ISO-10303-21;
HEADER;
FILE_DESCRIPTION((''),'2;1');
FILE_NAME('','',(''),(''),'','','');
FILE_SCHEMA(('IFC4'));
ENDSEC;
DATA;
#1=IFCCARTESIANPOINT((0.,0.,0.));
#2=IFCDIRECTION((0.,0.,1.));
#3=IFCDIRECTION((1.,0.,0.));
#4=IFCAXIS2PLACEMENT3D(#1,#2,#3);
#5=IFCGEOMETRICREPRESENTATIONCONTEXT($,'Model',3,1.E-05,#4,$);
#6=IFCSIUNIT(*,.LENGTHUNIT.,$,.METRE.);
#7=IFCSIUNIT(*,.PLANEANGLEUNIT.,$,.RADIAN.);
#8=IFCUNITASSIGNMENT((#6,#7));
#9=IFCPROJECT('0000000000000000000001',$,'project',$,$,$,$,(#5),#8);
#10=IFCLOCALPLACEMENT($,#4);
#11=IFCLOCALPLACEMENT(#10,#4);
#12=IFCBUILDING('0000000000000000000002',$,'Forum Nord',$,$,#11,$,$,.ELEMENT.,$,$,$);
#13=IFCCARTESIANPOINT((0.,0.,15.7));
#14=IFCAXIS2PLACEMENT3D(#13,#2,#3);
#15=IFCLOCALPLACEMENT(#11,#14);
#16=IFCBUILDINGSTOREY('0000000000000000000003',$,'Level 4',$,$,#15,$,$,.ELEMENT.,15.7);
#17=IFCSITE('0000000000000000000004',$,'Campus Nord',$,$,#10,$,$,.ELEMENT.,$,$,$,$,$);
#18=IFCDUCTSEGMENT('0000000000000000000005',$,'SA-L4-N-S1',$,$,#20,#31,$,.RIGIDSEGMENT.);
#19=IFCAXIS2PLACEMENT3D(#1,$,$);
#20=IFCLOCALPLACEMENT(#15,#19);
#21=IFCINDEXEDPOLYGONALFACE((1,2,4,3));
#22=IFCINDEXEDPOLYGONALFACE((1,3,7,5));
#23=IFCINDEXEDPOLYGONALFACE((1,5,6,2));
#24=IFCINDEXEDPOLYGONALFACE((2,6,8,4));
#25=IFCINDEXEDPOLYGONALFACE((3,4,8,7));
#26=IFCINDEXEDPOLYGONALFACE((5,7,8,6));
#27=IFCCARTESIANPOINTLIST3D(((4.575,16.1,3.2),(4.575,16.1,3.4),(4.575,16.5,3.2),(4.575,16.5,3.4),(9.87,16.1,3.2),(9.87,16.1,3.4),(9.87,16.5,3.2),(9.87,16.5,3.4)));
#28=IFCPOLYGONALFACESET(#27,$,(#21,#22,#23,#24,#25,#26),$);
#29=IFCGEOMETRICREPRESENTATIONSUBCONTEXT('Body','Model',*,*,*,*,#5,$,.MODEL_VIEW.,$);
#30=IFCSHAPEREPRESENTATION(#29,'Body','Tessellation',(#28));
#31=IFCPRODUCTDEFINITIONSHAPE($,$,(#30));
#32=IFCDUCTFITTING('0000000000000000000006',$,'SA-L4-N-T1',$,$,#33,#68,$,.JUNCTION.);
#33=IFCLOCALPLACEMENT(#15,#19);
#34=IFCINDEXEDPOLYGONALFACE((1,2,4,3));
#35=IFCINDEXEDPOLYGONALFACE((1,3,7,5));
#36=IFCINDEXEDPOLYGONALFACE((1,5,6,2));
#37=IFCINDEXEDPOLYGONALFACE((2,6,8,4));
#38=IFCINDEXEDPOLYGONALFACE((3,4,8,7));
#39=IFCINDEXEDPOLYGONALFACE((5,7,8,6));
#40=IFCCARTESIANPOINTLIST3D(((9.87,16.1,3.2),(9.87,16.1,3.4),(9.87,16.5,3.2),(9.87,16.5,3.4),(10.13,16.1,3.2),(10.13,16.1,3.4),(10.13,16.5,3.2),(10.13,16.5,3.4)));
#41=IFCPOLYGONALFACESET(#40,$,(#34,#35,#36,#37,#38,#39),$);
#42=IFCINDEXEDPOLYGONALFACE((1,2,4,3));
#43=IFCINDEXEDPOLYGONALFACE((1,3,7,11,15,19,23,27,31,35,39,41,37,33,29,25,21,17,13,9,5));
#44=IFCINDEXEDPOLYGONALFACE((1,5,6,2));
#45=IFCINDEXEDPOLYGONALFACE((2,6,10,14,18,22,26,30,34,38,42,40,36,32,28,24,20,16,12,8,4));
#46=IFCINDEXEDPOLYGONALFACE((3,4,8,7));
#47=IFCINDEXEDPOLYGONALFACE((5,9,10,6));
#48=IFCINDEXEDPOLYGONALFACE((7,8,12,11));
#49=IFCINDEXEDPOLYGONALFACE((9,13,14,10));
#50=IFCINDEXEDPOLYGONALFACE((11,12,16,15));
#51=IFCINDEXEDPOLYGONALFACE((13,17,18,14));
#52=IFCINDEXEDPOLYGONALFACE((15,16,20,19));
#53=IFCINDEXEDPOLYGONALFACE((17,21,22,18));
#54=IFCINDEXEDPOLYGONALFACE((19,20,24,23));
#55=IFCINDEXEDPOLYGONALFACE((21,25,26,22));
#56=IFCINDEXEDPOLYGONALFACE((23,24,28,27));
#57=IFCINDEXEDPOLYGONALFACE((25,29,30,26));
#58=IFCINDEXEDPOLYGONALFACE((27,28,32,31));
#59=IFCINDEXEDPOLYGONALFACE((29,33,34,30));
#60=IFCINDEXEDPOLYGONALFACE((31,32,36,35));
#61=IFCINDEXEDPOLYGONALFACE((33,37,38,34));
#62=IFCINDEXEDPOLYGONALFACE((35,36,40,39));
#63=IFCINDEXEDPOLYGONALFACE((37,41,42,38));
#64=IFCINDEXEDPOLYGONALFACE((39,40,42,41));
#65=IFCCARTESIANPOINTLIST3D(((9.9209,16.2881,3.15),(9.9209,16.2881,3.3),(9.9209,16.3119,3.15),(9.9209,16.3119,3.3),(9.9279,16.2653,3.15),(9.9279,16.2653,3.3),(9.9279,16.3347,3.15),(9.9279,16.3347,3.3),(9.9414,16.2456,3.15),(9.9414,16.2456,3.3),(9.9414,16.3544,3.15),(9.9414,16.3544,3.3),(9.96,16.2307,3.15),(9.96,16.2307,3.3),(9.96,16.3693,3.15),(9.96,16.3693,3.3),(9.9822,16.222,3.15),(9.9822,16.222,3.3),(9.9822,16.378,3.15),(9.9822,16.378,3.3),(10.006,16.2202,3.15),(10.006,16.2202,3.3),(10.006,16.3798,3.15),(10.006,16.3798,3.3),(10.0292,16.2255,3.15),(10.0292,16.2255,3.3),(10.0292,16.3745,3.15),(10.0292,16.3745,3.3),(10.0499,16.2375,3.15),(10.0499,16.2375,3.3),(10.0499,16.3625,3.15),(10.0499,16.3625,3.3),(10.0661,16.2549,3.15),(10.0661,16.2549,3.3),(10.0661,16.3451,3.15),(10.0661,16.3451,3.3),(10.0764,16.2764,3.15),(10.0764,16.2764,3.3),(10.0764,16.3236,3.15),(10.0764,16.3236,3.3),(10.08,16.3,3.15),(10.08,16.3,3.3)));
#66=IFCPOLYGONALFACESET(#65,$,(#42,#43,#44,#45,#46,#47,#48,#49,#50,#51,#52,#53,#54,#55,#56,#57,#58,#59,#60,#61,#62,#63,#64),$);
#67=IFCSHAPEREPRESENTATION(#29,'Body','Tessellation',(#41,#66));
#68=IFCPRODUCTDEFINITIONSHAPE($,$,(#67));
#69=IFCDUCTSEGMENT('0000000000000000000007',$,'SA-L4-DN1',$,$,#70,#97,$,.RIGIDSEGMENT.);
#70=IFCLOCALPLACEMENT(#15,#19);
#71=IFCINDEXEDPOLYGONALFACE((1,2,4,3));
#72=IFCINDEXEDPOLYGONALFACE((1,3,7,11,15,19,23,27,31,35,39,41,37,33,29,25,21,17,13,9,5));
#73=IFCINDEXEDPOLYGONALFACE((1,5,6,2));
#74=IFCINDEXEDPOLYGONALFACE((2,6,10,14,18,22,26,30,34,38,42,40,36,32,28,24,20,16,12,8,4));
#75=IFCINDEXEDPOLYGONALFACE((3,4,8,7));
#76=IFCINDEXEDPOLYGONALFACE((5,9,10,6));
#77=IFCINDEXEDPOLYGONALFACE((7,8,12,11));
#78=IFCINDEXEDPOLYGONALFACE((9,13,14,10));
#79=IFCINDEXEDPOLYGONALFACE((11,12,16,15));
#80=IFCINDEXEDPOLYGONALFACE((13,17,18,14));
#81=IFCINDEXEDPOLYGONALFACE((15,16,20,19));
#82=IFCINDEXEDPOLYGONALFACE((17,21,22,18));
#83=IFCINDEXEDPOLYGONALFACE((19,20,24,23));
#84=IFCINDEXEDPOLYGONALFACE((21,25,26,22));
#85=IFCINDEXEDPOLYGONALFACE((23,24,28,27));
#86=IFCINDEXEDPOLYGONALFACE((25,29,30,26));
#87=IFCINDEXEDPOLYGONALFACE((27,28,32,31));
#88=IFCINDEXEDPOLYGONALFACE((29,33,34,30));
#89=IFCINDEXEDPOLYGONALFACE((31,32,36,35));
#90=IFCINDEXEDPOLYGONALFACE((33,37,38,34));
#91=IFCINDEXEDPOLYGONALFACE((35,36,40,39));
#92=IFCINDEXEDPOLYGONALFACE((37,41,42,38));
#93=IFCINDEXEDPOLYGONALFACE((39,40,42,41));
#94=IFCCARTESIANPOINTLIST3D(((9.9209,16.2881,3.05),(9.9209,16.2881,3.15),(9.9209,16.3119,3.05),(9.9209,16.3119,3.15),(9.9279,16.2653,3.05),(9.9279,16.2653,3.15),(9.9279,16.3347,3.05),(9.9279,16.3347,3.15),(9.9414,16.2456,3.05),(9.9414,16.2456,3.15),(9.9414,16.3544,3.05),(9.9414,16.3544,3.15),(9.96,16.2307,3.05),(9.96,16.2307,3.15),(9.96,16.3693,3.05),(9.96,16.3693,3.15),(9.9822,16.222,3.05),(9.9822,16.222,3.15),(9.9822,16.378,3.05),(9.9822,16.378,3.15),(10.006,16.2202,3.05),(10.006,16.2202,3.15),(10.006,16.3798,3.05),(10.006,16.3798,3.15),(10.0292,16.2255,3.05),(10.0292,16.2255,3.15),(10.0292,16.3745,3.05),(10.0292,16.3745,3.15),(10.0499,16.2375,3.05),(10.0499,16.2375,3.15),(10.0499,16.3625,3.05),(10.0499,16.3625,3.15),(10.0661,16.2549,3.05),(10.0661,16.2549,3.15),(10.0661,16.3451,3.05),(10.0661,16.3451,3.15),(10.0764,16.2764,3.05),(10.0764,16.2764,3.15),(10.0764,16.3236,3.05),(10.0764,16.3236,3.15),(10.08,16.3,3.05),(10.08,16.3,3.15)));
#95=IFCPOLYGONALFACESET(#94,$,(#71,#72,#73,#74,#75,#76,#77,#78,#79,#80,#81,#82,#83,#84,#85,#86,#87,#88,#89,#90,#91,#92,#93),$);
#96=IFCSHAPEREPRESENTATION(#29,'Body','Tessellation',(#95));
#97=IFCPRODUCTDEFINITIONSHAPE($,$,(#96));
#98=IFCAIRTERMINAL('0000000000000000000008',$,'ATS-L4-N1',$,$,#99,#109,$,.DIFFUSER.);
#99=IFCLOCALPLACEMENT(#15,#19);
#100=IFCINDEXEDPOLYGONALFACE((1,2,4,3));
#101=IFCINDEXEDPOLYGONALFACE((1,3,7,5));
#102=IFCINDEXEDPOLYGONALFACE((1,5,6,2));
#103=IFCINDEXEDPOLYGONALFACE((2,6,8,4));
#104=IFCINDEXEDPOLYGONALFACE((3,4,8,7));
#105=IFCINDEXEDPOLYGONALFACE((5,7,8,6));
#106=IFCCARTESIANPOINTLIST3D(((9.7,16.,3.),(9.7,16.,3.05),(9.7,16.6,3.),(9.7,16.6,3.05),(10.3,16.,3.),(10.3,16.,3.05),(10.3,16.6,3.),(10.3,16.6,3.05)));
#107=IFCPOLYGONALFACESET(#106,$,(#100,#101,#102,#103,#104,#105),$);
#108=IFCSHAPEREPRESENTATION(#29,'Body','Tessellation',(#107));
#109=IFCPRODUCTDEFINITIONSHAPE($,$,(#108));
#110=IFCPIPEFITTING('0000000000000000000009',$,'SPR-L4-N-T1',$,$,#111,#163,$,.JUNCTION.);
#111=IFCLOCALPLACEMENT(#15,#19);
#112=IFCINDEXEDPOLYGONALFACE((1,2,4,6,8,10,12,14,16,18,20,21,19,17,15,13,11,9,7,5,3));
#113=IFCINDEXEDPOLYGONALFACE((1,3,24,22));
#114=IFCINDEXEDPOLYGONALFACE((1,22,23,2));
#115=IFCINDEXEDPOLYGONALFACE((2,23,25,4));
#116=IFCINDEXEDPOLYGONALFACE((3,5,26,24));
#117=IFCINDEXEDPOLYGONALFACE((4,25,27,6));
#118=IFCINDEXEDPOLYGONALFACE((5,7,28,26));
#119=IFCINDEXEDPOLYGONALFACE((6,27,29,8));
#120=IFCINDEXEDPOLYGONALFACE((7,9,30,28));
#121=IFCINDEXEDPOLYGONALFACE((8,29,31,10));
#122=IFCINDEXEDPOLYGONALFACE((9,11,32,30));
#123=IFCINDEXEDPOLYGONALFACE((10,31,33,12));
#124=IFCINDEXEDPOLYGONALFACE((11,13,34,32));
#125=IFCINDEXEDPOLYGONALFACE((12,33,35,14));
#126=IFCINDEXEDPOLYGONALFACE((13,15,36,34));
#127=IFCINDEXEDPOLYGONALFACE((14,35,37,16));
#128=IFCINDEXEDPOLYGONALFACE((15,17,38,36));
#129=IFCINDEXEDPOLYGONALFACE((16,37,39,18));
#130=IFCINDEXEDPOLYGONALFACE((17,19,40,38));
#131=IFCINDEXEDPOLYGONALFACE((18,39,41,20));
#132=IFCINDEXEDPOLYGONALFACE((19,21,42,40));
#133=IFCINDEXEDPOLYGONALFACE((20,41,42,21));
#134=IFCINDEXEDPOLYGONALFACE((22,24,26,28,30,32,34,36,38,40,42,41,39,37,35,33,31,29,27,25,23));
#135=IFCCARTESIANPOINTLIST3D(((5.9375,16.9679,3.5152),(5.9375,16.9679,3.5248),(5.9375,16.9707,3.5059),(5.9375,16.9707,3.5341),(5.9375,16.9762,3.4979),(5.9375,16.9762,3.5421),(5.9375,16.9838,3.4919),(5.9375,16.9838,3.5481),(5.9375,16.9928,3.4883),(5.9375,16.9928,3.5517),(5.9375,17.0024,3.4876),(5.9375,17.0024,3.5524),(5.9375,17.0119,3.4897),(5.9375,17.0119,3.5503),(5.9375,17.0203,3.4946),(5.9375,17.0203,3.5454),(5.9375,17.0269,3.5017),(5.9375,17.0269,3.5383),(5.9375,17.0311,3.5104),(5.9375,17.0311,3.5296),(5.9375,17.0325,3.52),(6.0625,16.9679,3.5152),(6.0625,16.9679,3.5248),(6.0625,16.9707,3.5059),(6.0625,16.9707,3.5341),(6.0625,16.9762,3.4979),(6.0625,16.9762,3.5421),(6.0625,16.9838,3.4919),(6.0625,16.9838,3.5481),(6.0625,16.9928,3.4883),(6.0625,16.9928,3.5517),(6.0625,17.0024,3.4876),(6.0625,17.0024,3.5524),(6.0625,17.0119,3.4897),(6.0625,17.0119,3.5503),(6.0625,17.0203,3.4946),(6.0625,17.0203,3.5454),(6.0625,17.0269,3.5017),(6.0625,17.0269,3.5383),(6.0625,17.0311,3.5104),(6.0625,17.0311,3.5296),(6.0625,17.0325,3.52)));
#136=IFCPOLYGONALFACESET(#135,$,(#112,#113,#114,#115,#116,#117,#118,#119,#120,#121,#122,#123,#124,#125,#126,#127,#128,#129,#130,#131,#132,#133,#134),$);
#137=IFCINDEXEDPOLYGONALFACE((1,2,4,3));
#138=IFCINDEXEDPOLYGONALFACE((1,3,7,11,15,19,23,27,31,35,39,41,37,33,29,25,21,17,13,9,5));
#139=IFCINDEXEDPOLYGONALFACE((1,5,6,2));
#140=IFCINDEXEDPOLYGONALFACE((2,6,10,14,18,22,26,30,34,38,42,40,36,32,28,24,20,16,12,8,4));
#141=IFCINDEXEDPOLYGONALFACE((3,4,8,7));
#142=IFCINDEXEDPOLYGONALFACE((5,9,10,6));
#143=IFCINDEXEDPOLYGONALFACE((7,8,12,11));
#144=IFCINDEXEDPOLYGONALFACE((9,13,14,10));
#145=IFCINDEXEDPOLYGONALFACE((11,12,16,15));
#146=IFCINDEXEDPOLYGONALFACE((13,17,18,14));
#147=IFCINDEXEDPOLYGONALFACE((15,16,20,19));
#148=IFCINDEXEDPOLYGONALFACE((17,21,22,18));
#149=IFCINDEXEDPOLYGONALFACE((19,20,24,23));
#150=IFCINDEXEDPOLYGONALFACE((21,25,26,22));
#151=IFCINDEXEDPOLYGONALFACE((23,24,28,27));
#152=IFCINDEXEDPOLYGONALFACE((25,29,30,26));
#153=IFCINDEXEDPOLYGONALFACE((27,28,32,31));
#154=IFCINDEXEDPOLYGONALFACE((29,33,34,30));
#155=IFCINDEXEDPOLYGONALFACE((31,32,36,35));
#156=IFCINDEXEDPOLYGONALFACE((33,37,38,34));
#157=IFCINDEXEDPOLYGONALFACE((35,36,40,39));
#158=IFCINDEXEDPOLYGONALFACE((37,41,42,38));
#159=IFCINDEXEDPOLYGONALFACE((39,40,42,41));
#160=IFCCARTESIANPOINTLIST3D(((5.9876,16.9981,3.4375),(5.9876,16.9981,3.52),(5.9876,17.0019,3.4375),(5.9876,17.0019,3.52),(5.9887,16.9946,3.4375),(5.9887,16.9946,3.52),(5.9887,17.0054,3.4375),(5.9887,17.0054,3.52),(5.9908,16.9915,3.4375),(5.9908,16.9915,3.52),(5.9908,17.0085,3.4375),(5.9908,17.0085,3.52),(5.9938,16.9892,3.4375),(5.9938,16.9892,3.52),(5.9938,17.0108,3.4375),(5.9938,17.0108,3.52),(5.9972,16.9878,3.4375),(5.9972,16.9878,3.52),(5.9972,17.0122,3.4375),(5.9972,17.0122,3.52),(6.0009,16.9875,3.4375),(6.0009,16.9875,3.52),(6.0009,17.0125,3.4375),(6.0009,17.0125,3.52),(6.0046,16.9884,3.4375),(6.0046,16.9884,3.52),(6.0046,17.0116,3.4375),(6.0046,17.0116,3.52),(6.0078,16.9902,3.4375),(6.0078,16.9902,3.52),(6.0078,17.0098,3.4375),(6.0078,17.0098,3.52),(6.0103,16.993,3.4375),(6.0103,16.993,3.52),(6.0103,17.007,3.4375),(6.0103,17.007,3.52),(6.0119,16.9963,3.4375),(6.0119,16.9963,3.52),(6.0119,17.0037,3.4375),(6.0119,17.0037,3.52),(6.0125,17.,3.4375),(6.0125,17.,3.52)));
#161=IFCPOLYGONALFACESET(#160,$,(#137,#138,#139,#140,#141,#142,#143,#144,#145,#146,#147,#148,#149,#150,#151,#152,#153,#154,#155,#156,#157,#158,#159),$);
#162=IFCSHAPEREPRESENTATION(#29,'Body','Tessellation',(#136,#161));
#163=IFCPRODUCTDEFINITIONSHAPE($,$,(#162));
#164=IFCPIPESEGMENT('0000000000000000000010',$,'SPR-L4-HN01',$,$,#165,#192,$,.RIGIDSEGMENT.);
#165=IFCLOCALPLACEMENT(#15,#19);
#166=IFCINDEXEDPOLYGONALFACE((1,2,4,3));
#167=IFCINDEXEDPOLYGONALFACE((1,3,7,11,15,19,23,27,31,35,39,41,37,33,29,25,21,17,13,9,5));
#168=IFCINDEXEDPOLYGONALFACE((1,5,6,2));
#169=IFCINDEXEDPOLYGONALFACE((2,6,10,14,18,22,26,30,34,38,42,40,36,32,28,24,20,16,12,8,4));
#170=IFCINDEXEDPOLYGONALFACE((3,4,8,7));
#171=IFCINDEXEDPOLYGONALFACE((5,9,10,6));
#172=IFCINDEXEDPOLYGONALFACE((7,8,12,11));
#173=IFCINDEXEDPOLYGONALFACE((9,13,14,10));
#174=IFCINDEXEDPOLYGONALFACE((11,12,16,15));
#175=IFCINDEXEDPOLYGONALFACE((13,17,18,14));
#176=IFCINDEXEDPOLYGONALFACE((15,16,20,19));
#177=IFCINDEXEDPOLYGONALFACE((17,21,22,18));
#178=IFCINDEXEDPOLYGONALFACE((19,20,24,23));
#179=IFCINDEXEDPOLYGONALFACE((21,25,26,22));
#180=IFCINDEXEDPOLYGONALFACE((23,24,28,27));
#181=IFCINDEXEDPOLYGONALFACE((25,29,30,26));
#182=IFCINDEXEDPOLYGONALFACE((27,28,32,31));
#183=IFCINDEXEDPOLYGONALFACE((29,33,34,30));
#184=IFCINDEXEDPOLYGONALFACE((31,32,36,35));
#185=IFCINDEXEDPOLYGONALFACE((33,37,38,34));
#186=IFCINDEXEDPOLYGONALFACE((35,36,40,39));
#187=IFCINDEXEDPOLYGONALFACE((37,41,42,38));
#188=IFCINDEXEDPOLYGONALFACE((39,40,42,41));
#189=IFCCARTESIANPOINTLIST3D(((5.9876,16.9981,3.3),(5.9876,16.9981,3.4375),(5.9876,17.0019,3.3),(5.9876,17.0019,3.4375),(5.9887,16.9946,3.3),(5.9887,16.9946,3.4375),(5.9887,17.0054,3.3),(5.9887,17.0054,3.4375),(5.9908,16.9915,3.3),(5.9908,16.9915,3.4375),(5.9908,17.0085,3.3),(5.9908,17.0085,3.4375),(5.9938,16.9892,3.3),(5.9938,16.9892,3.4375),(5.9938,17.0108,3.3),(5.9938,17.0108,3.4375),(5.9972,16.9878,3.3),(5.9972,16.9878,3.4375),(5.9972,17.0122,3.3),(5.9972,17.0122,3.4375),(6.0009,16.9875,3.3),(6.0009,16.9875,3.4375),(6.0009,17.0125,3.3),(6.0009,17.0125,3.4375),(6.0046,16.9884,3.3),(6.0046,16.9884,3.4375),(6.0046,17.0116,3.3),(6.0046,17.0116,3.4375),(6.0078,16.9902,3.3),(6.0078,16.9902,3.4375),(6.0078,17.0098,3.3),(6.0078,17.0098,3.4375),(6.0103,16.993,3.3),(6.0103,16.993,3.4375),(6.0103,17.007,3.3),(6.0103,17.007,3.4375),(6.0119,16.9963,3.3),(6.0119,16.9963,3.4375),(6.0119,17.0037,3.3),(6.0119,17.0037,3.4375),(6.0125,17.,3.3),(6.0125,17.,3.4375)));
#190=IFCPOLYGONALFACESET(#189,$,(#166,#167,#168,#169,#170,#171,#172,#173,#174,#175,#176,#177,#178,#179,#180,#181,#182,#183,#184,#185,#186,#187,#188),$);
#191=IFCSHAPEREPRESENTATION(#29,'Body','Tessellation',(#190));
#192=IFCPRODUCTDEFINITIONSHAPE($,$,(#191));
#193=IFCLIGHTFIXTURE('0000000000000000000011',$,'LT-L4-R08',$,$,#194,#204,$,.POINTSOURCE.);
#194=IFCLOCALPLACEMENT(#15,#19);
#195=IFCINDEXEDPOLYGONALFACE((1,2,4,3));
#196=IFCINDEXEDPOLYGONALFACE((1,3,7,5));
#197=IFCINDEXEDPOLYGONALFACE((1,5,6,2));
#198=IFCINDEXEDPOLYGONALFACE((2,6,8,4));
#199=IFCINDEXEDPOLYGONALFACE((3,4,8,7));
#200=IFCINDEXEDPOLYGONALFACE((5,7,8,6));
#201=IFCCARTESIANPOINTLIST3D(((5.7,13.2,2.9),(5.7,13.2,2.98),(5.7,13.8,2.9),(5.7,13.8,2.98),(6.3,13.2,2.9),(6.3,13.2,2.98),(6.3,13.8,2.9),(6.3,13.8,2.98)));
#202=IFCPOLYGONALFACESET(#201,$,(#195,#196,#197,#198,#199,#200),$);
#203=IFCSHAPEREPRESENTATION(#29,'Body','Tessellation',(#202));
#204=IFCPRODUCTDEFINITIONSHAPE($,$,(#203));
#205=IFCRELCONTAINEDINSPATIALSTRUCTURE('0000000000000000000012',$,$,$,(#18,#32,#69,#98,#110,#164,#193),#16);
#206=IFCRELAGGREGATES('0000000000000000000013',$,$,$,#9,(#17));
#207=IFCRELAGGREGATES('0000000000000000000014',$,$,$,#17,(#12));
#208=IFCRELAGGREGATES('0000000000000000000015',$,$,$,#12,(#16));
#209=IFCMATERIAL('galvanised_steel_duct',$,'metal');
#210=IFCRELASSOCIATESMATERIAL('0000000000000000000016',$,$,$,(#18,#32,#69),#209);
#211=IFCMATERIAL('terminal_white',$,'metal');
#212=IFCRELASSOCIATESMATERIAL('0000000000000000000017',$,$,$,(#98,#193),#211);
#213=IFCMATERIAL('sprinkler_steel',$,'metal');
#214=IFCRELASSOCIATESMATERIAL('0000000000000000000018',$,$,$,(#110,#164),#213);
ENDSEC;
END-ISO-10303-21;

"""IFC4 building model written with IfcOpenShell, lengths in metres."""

from ifc_helpers import new_model, si_unit, frame, origin_with_axes, origin_2d_with_axis, place, context, subcontext, project, spatial, rectangle, circle, extrude, material, element, save


model = new_model("IFC4")

# Units and contexts
model_context = context("Model", 3, precision=1e-05, world=origin_with_axes())
body_context = subcontext(model_context, "Body", "Model", "MODEL_VIEW")
ifc_project = project(units=[si_unit("LENGTHUNIT", "METRE"), si_unit("PLANEANGLEUNIT", "RADIAN")], contexts=[model_context])

# Site, building, storey
site_placement = place(None, origin_with_axes())
site = spatial("IfcSite", under=ifc_project, at=site_placement, Name="Campus Nord", CompositionType="ELEMENT")
building_placement = place(site_placement, origin_with_axes())
building = spatial("IfcBuilding", under=site, at=building_placement, Name="Forum Nord", CompositionType="ELEMENT")
storey_placement = place(building_placement, frame((0.0, 0.0, 15.7), z_axis=(0.0, 0.0, 1.0), x_axis=(1.0, 0.0, 0.0)))
storey = spatial("IfcBuildingStorey", under=building, at=storey_placement, Name="Level 4", CompositionType="ELEMENT", Elevation=15.7)

# Duct segment
ifc_material_1 = material(Name="galvanised_steel_duct", Category="metal")
duct_segment_1_placement = place(storey_placement, frame((4.575, 16.3, 3.3), z_axis=(1.0, 0.0, 0.0), x_axis=(0.0, 1.0, 0.0)))
element("IfcDuctSegment", 1, at=duct_segment_1_placement, inside=storey, material=ifc_material_1, Name="SA-L4-N-S1", PredefinedType="RIGIDSEGMENT", context=body_context, shape_type="SweptSolid", body=[
    extrude(rectangle(XDim=0.4, YDim=0.2, at=origin_2d_with_axis()), origin_with_axes(), (0.0, 0.0, 1.0), 5.295),
])

# Duct fitting
duct_fitting_placement = place(storey_placement, frame((9.87, 16.3, 3.3), z_axis=(1.0, 0.0, 0.0), x_axis=(0.0, 1.0, 0.0)))
element("IfcDuctFitting", 2, at=duct_fitting_placement, inside=storey, material=ifc_material_1, Name="SA-L4-N-T1", PredefinedType="JUNCTION", context=body_context, shape_type="SweptSolid", body=[
    extrude(rectangle(XDim=0.4, YDim=0.2, at=origin_2d_with_axis()), origin_with_axes(), (0.0, 0.0, 1.0), 0.26),
    extrude(circle(Radius=0.08, at=origin_2d_with_axis()), frame((0.0, 0.0, 0.13), z_axis=(0.0, -1.0, 0.0), x_axis=(0.0, 0.0, 1.0)), (0.0, 0.0, 1.0), 0.15),
])

# Duct segment
duct_segment_2_placement = place(storey_placement, frame((10.0, 16.3, 3.15), z_axis=(0.0, 0.0, -1.0), x_axis=(1.0, 0.0, 0.0)))
element("IfcDuctSegment", 3, at=duct_segment_2_placement, inside=storey, material=ifc_material_1, Name="SA-L4-DN1", PredefinedType="RIGIDSEGMENT", context=body_context, shape_type="SweptSolid", body=[
    extrude(circle(Radius=0.08, at=origin_2d_with_axis()), origin_with_axes(), (0.0, 0.0, 1.0), 0.1),
])

# Air terminal
ifc_material_2 = material(Name="terminal_white", Category="metal")
air_terminal_placement = place(storey_placement, frame((10.0, 16.3, 3.0), z_axis=(0.0, 0.0, 1.0), x_axis=(1.0, 0.0, 0.0)))
element("IfcAirTerminal", 4, at=air_terminal_placement, inside=storey, material=ifc_material_2, Name="ATS-L4-N1", PredefinedType="DIFFUSER", context=body_context, shape_type="SweptSolid", body=[
    extrude(rectangle(XDim=0.6, YDim=0.6, at=origin_2d_with_axis()), origin_with_axes(), (0.0, 0.0, 1.0), 0.05),
])

# Pipe fitting
ifc_material_3 = material(Name="sprinkler_steel", Category="metal")
pipe_fitting_placement = place(storey_placement, frame((5.9375, 17.0, 3.52), z_axis=(1.0, 0.0, 0.0), x_axis=(0.0, 1.0, 0.0)))
element("IfcPipeFitting", 5, at=pipe_fitting_placement, inside=storey, material=ifc_material_3, Name="SPR-L4-N-T1", PredefinedType="JUNCTION", context=body_context, shape_type="SweptSolid", body=[
    extrude(circle(Radius=0.0325, at=origin_2d_with_axis()), origin_with_axes(), (0.0, 0.0, 1.0), 0.125),
    extrude(circle(Radius=0.0125, at=origin_2d_with_axis()), frame((0.0, 0.0, 0.0625), z_axis=(0.0, -1.0, 0.0), x_axis=(0.0, 0.0, 1.0)), (0.0, 0.0, 1.0), 0.0825),
])

# Pipe segment
pipe_segment_placement = place(storey_placement, frame((6.0, 17.0, 3.4375), z_axis=(0.0, 0.0, -1.0), x_axis=(1.0, 0.0, 0.0)))
element("IfcPipeSegment", 6, at=pipe_segment_placement, inside=storey, material=ifc_material_3, Name="SPR-L4-HN01", PredefinedType="RIGIDSEGMENT", context=body_context, shape_type="SweptSolid", body=[
    extrude(circle(Radius=0.0125, at=origin_2d_with_axis()), origin_with_axes(), (0.0, 0.0, 1.0), 0.1375),
])

# Light fixture
for number, where, z_axis, x_axis, name in (
    (7, (6.0, 13.5, 2.9), (0.0, 0.0, 1.0), (1.0, 0.0, 0.0), "LT-L4-R08"),
):
    element("IfcLightFixture", number, at=place(storey_placement, frame(where, z_axis=z_axis, x_axis=x_axis)), inside=storey, material=ifc_material_2, Name=name, PredefinedType="POINTSOURCE", context=body_context, shape_type="SweptSolid", body=[
        extrude(rectangle(XDim=0.6, YDim=0.6, at=origin_2d_with_axis()), origin_with_axes(), (0.0, 0.0, 1.0), 0.08),
    ])

save(model, "model.ifc")
